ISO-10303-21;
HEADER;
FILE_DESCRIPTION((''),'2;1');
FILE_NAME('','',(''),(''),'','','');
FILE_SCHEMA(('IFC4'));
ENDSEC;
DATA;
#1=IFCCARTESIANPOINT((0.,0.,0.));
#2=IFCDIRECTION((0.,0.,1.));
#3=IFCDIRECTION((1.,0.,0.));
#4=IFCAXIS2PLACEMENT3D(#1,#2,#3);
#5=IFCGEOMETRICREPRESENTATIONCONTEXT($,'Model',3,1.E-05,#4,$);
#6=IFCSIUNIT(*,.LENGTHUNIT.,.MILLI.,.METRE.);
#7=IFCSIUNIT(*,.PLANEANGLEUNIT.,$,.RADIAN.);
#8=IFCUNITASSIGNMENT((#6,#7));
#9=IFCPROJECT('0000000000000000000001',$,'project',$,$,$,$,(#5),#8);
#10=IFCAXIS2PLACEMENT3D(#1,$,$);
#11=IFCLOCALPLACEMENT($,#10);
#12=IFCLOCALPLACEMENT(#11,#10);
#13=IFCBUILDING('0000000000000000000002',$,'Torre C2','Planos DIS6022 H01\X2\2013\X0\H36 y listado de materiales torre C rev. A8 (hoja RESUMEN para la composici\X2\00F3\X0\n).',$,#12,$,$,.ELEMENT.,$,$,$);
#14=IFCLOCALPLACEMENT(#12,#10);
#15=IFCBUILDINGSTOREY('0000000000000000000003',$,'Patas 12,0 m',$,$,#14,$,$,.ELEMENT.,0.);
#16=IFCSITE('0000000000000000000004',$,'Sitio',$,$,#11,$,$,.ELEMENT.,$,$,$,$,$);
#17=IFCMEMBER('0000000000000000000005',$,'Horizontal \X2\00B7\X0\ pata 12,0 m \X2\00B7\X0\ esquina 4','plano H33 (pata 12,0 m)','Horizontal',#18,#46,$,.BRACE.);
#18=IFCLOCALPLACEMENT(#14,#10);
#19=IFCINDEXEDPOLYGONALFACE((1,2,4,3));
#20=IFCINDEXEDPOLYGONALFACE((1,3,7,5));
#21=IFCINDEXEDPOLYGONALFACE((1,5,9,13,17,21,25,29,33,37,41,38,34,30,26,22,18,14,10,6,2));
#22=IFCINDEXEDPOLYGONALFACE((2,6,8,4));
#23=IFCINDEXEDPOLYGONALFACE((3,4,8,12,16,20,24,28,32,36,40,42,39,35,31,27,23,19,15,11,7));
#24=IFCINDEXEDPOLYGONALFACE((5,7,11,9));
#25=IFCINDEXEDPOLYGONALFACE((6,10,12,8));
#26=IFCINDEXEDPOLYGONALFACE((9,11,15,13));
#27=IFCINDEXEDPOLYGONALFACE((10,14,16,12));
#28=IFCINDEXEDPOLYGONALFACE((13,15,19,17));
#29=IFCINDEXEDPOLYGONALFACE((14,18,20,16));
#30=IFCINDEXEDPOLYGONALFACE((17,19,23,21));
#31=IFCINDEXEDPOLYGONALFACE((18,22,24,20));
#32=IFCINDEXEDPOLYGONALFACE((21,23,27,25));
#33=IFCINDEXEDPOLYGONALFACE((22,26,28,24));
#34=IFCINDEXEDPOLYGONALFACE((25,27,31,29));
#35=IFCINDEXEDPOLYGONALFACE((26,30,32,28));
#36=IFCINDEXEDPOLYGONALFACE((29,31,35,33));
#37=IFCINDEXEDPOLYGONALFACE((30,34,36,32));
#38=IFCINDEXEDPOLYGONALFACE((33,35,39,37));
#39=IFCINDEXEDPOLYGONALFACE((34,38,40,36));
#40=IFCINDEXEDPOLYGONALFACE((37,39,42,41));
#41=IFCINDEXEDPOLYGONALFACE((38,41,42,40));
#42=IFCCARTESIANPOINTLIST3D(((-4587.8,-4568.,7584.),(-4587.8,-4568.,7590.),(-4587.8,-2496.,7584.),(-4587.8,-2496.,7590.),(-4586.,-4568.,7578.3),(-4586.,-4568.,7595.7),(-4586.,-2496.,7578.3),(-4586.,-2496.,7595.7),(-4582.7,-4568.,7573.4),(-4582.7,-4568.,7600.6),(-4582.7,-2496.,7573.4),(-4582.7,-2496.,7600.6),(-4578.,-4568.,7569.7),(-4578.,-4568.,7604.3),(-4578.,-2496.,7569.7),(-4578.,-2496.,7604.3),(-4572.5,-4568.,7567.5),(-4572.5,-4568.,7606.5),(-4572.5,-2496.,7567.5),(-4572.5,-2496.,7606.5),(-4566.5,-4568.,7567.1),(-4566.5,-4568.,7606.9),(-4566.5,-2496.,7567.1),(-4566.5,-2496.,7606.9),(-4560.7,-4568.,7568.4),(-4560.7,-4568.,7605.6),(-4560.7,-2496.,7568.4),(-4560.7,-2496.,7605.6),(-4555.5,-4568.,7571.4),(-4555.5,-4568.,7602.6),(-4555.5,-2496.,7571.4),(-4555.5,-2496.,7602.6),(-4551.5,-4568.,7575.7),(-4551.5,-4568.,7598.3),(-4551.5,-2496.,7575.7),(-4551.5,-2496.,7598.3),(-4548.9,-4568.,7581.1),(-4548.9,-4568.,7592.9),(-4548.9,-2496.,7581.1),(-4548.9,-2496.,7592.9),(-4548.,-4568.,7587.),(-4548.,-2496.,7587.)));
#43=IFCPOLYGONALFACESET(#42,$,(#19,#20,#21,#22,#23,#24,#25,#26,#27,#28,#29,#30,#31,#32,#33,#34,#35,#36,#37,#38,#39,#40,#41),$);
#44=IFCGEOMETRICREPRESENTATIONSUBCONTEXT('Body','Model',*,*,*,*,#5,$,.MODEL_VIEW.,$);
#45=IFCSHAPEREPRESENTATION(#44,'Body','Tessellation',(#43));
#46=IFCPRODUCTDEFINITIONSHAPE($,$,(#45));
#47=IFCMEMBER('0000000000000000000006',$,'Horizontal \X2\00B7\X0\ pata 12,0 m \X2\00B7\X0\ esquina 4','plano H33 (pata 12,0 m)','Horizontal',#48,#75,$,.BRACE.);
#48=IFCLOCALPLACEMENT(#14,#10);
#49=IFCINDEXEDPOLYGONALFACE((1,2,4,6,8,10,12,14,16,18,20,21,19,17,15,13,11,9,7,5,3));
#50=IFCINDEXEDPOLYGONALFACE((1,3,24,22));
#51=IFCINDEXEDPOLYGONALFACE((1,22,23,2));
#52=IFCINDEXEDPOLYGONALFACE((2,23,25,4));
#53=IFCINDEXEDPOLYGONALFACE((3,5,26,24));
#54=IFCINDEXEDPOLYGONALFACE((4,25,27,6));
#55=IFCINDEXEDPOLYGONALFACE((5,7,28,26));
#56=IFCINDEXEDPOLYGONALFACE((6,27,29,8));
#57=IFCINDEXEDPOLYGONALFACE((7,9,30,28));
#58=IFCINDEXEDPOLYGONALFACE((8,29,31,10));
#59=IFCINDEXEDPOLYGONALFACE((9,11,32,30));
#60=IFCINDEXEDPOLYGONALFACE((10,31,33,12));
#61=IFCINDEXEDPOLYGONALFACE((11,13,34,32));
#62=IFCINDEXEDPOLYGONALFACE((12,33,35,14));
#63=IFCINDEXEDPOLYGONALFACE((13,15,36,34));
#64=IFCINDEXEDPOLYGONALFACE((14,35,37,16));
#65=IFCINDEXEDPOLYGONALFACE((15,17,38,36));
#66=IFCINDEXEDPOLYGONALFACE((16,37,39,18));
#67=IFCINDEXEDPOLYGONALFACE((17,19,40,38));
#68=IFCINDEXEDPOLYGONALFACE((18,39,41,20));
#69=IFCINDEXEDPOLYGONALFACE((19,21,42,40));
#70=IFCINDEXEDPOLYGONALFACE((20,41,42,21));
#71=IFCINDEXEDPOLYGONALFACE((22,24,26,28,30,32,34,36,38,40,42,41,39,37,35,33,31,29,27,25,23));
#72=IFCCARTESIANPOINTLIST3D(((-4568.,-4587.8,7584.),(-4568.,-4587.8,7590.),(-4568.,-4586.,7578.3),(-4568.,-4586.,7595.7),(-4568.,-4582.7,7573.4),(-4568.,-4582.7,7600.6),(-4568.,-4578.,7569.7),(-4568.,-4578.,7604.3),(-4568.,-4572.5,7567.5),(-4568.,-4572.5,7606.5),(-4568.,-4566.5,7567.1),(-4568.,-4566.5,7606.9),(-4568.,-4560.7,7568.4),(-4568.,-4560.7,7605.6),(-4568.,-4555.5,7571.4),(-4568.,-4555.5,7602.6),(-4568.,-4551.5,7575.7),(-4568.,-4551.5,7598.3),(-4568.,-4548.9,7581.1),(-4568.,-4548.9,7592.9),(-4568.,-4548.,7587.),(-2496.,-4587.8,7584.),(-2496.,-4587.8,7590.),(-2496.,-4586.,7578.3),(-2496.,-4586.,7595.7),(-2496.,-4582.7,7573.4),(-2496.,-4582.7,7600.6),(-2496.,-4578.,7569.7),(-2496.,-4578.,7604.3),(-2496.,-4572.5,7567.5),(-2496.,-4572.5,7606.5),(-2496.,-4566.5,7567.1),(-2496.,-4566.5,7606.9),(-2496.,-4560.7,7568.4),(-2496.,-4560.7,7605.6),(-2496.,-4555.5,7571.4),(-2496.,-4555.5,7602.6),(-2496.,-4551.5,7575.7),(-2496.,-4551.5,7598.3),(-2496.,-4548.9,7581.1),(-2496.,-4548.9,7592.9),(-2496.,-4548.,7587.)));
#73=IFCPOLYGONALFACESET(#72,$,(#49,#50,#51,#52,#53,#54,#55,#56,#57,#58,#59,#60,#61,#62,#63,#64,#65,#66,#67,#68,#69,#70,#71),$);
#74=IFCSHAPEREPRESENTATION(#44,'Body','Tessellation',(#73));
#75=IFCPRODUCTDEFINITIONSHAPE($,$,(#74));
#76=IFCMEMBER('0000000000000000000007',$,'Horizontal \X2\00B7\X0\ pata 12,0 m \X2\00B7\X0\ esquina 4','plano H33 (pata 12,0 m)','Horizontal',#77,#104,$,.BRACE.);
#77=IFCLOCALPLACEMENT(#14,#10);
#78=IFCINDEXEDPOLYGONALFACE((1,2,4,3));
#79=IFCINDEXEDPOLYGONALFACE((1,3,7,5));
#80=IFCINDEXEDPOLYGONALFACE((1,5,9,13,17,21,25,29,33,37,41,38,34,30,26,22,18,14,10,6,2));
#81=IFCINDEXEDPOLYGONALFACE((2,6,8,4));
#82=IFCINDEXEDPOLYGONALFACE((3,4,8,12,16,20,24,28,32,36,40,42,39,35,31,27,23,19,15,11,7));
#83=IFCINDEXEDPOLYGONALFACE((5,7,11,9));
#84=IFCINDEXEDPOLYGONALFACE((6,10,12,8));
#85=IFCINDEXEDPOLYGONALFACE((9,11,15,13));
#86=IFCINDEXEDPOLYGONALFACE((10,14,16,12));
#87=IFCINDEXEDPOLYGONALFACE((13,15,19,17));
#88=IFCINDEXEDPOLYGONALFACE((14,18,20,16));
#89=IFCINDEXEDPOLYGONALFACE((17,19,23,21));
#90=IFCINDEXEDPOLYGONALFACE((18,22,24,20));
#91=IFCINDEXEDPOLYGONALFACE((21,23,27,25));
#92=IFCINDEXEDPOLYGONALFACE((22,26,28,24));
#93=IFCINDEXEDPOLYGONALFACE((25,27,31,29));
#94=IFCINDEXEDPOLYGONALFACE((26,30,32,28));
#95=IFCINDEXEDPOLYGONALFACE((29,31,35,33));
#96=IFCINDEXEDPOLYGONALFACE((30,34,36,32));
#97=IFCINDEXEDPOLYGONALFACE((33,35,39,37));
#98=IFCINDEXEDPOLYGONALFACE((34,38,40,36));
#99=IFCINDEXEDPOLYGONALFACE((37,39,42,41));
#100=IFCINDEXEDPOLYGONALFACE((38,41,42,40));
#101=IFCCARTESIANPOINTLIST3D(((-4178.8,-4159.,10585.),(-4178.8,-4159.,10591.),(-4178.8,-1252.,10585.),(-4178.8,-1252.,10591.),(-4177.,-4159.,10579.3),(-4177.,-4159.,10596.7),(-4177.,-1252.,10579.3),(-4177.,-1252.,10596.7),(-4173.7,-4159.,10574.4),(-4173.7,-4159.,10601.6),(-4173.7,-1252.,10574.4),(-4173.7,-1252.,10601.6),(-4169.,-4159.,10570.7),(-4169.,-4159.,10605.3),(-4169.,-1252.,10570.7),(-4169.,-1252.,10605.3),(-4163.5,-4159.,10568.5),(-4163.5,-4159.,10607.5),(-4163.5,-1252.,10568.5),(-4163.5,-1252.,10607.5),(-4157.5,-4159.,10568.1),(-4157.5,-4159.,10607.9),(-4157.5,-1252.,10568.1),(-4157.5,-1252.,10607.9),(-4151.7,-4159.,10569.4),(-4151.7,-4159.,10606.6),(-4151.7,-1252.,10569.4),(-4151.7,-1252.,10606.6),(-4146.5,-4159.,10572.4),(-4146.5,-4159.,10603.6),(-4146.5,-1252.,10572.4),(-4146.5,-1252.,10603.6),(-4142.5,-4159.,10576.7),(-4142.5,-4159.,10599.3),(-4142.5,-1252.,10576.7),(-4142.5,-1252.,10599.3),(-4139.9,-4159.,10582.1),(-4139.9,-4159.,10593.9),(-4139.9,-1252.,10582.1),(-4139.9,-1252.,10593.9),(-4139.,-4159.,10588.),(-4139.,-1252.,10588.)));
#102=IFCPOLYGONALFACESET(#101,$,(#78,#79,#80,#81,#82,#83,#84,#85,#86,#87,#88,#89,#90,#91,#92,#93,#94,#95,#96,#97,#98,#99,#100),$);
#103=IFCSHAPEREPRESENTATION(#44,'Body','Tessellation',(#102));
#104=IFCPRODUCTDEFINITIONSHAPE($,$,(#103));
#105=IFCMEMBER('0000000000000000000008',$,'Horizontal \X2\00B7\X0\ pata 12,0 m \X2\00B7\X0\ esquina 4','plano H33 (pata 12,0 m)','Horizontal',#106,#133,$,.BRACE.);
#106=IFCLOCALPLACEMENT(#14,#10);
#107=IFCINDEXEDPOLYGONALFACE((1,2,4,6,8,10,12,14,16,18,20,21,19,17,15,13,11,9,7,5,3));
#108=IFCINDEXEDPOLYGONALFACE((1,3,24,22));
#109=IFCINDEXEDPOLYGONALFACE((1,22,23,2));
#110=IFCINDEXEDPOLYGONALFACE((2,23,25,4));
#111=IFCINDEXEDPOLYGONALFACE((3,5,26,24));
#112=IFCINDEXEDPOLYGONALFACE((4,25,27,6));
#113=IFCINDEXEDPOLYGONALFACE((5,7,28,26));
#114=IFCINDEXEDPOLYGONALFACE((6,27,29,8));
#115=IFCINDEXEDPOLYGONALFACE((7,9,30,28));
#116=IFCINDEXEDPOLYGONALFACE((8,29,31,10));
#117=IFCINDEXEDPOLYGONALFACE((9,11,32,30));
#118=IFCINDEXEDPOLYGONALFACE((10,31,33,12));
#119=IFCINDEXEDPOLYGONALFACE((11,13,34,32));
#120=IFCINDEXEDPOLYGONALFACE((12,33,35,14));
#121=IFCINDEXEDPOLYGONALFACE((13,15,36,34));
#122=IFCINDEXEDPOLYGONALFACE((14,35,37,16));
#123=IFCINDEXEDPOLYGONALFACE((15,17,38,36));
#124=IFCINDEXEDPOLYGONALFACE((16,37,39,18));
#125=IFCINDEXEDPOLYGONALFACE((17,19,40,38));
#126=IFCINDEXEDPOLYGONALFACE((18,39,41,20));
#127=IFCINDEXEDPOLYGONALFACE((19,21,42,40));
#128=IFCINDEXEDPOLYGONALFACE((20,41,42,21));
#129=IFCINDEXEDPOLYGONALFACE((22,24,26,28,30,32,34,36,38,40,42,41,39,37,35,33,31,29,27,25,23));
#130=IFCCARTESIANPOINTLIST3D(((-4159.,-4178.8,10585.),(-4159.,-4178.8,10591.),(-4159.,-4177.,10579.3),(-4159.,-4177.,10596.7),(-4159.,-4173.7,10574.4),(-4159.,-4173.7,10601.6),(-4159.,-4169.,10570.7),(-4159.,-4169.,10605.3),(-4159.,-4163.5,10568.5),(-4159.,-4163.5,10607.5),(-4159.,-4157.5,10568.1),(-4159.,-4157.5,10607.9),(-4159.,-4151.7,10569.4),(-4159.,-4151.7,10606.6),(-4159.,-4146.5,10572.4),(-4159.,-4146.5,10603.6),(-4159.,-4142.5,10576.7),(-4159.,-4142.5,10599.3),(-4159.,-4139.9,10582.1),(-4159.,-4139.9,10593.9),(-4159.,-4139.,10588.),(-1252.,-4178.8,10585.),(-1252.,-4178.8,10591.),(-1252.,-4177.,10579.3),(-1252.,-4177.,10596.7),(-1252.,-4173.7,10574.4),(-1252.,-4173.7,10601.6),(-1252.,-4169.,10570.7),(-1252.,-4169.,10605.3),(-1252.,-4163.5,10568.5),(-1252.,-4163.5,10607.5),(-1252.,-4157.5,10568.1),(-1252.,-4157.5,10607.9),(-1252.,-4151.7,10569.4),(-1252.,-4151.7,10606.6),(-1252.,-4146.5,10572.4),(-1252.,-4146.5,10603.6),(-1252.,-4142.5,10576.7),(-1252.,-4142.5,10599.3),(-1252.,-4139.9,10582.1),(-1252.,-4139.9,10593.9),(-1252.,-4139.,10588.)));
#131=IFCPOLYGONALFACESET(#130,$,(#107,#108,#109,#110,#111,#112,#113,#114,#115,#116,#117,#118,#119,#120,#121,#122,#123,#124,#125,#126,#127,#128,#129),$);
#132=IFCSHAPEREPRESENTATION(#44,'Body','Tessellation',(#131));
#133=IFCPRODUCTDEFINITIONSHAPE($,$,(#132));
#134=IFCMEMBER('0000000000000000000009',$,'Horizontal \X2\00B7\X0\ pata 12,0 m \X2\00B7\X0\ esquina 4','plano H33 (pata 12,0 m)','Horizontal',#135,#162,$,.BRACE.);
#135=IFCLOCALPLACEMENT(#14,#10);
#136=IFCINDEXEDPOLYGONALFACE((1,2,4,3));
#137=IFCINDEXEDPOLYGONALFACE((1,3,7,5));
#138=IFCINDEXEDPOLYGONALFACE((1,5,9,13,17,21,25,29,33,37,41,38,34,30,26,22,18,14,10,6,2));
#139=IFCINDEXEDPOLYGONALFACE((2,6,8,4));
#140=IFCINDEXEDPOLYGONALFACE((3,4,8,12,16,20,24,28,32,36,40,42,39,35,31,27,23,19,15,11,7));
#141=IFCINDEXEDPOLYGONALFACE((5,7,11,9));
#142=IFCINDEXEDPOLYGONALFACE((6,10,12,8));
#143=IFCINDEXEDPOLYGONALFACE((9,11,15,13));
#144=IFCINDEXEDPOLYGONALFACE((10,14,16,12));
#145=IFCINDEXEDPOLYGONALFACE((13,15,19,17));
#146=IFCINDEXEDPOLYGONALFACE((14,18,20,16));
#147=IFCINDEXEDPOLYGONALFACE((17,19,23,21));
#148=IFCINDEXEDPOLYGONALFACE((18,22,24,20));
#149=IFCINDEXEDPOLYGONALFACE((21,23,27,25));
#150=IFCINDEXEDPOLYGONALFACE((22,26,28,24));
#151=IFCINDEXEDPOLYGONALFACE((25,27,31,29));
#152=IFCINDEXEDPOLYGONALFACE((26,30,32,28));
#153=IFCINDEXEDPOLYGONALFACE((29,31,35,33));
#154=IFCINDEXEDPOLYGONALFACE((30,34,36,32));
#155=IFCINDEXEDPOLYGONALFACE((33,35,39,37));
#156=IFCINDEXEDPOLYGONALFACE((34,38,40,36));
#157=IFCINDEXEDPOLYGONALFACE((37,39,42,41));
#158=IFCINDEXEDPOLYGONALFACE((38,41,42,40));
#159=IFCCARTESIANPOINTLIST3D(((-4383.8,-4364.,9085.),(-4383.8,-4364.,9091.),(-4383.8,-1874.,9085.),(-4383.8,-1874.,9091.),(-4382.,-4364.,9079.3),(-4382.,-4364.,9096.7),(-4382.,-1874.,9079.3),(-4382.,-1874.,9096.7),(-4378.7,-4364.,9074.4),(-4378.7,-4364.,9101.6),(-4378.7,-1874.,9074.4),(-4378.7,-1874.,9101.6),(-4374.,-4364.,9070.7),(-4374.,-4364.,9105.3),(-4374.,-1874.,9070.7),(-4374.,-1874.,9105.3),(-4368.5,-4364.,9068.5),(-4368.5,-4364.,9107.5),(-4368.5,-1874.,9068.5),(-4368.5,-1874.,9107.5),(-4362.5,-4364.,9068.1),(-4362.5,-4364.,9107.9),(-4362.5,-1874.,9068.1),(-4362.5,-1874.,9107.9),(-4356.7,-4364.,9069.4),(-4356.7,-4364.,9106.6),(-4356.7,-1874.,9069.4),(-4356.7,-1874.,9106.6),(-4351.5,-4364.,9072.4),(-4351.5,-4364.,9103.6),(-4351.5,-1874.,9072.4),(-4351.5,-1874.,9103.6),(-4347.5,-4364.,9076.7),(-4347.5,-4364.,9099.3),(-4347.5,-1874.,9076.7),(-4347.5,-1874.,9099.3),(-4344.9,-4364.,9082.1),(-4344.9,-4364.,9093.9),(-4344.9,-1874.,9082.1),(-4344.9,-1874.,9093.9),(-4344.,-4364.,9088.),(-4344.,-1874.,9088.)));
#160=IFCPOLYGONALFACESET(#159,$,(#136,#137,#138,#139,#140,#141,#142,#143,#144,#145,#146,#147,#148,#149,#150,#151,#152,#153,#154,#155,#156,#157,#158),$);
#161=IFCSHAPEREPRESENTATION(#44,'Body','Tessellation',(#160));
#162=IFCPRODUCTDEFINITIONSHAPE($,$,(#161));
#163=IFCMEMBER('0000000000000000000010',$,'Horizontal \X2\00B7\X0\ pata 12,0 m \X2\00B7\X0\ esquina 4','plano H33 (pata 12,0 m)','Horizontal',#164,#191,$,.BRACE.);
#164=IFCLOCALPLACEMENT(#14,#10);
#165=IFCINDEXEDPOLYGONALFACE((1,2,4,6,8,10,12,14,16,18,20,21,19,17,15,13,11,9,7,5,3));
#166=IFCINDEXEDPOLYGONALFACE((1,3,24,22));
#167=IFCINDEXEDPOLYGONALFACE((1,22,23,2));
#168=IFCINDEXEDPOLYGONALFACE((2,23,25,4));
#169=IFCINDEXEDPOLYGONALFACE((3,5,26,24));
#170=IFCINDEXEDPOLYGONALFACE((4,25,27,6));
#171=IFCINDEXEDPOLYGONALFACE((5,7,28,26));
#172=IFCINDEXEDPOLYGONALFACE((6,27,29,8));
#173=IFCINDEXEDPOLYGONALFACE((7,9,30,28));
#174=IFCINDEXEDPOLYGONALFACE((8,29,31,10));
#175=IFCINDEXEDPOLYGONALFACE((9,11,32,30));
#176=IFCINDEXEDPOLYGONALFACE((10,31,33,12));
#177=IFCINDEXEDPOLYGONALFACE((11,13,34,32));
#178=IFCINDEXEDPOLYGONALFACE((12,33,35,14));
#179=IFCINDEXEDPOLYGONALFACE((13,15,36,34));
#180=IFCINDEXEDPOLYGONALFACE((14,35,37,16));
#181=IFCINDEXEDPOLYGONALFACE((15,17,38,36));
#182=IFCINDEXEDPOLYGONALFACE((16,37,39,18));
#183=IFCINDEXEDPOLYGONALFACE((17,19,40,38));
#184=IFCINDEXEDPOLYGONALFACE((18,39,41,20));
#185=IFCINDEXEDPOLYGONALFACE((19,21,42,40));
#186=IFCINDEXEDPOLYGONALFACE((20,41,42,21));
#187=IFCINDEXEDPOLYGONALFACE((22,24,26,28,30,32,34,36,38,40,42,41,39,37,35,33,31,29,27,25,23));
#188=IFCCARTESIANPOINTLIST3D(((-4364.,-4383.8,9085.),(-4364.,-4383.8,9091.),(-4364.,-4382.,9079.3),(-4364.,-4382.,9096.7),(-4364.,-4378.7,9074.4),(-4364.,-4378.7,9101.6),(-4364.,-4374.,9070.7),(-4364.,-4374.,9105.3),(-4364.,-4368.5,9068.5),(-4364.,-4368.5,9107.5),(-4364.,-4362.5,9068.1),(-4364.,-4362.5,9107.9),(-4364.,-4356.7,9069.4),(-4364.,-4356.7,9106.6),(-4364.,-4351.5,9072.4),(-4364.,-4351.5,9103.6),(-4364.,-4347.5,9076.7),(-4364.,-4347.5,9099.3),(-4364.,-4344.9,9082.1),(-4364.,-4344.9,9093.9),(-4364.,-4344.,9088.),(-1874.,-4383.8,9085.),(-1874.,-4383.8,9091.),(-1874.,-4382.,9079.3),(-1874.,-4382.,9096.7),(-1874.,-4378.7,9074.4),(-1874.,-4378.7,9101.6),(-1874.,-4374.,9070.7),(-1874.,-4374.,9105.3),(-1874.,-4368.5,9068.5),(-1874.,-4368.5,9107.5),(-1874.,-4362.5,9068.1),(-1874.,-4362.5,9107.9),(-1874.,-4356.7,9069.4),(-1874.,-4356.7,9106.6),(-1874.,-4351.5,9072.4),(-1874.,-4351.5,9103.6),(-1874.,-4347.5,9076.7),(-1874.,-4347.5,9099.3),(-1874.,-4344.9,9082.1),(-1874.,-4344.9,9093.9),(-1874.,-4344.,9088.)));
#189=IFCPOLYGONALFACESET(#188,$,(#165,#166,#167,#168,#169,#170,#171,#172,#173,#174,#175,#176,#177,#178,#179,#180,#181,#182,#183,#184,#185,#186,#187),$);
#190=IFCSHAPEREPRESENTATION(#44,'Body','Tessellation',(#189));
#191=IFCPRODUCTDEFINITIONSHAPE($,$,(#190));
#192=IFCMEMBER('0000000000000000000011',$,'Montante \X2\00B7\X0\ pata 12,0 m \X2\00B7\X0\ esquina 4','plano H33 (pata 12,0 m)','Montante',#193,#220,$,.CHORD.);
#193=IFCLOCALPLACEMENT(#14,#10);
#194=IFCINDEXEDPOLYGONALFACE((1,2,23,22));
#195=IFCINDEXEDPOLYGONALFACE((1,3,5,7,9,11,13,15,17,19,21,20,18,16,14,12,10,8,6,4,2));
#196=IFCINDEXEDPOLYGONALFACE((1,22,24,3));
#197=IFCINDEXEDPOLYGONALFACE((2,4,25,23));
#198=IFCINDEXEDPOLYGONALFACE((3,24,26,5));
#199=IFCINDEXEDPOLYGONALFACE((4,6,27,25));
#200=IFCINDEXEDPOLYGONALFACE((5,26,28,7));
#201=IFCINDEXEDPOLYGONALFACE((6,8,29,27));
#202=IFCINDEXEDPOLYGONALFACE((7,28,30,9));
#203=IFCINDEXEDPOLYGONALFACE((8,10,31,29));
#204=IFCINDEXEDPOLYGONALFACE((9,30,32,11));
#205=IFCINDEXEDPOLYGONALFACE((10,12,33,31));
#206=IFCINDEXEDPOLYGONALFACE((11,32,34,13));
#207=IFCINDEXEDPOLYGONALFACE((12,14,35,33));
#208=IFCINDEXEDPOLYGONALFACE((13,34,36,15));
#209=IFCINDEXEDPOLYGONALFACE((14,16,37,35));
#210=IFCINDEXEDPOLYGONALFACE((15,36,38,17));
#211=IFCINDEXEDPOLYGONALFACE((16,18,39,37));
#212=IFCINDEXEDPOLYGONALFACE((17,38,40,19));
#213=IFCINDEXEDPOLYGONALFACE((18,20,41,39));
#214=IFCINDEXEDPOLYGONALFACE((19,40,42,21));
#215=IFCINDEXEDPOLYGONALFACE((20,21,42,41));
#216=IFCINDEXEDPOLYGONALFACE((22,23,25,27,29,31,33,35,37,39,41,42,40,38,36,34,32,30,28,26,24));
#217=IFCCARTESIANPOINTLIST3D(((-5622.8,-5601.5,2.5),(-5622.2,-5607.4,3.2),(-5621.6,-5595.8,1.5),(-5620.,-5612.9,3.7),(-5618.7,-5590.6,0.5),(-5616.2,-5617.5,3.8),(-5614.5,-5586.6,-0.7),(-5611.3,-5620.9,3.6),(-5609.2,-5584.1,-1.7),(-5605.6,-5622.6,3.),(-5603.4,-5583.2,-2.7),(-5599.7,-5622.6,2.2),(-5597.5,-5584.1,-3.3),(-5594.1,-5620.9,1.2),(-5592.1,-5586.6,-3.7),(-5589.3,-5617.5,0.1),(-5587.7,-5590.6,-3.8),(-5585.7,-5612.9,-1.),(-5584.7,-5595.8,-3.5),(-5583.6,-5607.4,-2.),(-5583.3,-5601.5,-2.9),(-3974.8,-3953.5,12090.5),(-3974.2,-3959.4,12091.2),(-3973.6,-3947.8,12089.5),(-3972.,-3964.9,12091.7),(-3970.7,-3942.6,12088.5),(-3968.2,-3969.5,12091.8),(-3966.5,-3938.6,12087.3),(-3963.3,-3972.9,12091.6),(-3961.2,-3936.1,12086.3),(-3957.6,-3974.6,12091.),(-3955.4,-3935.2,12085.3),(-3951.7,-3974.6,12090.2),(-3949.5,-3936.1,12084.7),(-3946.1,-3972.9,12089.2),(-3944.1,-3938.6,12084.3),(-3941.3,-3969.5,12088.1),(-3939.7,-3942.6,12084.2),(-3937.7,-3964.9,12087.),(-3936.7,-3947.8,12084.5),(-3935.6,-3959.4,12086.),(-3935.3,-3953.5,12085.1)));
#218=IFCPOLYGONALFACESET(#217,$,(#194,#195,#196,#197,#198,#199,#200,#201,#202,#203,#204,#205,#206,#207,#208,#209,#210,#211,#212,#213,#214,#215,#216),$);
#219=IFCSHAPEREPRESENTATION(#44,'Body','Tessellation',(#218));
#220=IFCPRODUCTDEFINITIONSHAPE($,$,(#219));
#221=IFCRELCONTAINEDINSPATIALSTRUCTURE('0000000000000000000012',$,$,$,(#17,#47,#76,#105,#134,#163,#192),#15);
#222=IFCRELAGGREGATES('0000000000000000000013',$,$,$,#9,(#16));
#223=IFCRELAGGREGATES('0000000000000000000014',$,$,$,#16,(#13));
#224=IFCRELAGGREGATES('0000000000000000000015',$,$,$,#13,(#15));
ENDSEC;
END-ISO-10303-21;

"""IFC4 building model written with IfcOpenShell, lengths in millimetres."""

from ifc_helpers import new_model, si_unit, frame, origin, origin_with_axes, place, context, subcontext, project, spatial, circle, extrude, element, save


model = new_model("IFC4")

# Units and contexts
model_context = context("Model", 3, precision=1e-05, world=origin_with_axes())
body_context = subcontext(model_context, "Body", "Model", "MODEL_VIEW")
ifc_project = project(units=[si_unit("LENGTHUNIT", "METRE", prefix="MILLI"), si_unit("PLANEANGLEUNIT", "RADIAN")], contexts=[model_context])

# Site, building, storey
site_placement = place(None, origin())
site = spatial("IfcSite", under=ifc_project, at=site_placement, Name="Sitio", CompositionType="ELEMENT")
building_placement = place(site_placement, origin())
building = spatial("IfcBuilding", under=site, at=building_placement, Name="Torre C2", Description="Planos DIS6022 H01–H36 y listado de materiales torre C rev. A8 (hoja RESUMEN para la composición).", CompositionType="ELEMENT")
storey_placement = place(building_placement, origin())
storey = spatial("IfcBuildingStorey", under=building, at=storey_placement, Name="Patas 12,0 m", CompositionType="ELEMENT", Elevation=0.0)

# Members
for number, where, z_axis, x_axis, name in (
    (1, (-4568.0, -2496.0, 7587.0), (0.0, -1.0, 0.0), (1.0, 0.0, 0.0), "Horizontal · pata 12,0 m · esquina 4"),
    (2, (-2496.0, -4568.0, 7587.0), (-1.0, 0.0, 0.0), (0.0, 1.0, 0.0), "Horizontal · pata 12,0 m · esquina 4"),
):
    element("IfcMember", number, at=place(storey_placement, frame(where, z_axis=z_axis, x_axis=x_axis)), inside=storey, Name=name, Description="plano H33 (pata 12,0 m)", ObjectType="Horizontal", PredefinedType="BRACE", context=body_context, shape_type="SweptSolid", body=[
        extrude(circle(Radius=20.0), None, (0.0, 0.0, 1.0), 2072.0),
    ])
for number, where, z_axis, x_axis, name in (
    (3, (-4159.0, -4159.0, 10588.0), (0.0, 1.0, 0.0), (1.0, 0.0, 0.0), "Horizontal · pata 12,0 m · esquina 4"),
    (4, (-4159.0, -4159.0, 10588.0), (1.0, 0.0, 0.0), (0.0, 1.0, 0.0), "Horizontal · pata 12,0 m · esquina 4"),
):
    element("IfcMember", number, at=place(storey_placement, frame(where, z_axis=z_axis, x_axis=x_axis)), inside=storey, Name=name, Description="plano H33 (pata 12,0 m)", ObjectType="Horizontal", PredefinedType="BRACE", context=body_context, shape_type="SweptSolid", body=[
        extrude(circle(Radius=20.0), None, (0.0, 0.0, 1.0), 2907.0),
    ])
for number, where, z_axis, x_axis, name in (
    (5, (-4364.0, -4364.0, 9088.0), (0.0, 1.0, 0.0), (1.0, 0.0, 0.0), "Horizontal · pata 12,0 m · esquina 4"),
    (6, (-4364.0, -4364.0, 9088.0), (1.0, 0.0, 0.0), (0.0, 1.0, 0.0), "Horizontal · pata 12,0 m · esquina 4"),
):
    element("IfcMember", number, at=place(storey_placement, frame(where, z_axis=z_axis, x_axis=x_axis)), inside=storey, Name=name, Description="plano H33 (pata 12,0 m)", ObjectType="Horizontal", PredefinedType="BRACE", context=body_context, shape_type="SweptSolid", body=[
        extrude(circle(Radius=20.0), None, (0.0, 0.0, 1.0), 2490.0),
    ])
member_1_placement = place(storey_placement, frame((-3955.0, -3955.0, 12088.0), z_axis=(-0.133868, -0.133868, -0.981916), x_axis=(-0.018083, 0.990999, -0.132641)))
element("IfcMember", 7, at=member_1_placement, inside=storey, Name="Montante · pata 12,0 m · esquina 4", Description="plano H33 (pata 12,0 m)", ObjectType="Montante", PredefinedType="CHORD", context=body_context, shape_type="SweptSolid", body=[
    extrude(circle(Radius=20.0), None, (0.0, 0.0, 1.0), 12310.6),
])

save(model, "model.ifc")
